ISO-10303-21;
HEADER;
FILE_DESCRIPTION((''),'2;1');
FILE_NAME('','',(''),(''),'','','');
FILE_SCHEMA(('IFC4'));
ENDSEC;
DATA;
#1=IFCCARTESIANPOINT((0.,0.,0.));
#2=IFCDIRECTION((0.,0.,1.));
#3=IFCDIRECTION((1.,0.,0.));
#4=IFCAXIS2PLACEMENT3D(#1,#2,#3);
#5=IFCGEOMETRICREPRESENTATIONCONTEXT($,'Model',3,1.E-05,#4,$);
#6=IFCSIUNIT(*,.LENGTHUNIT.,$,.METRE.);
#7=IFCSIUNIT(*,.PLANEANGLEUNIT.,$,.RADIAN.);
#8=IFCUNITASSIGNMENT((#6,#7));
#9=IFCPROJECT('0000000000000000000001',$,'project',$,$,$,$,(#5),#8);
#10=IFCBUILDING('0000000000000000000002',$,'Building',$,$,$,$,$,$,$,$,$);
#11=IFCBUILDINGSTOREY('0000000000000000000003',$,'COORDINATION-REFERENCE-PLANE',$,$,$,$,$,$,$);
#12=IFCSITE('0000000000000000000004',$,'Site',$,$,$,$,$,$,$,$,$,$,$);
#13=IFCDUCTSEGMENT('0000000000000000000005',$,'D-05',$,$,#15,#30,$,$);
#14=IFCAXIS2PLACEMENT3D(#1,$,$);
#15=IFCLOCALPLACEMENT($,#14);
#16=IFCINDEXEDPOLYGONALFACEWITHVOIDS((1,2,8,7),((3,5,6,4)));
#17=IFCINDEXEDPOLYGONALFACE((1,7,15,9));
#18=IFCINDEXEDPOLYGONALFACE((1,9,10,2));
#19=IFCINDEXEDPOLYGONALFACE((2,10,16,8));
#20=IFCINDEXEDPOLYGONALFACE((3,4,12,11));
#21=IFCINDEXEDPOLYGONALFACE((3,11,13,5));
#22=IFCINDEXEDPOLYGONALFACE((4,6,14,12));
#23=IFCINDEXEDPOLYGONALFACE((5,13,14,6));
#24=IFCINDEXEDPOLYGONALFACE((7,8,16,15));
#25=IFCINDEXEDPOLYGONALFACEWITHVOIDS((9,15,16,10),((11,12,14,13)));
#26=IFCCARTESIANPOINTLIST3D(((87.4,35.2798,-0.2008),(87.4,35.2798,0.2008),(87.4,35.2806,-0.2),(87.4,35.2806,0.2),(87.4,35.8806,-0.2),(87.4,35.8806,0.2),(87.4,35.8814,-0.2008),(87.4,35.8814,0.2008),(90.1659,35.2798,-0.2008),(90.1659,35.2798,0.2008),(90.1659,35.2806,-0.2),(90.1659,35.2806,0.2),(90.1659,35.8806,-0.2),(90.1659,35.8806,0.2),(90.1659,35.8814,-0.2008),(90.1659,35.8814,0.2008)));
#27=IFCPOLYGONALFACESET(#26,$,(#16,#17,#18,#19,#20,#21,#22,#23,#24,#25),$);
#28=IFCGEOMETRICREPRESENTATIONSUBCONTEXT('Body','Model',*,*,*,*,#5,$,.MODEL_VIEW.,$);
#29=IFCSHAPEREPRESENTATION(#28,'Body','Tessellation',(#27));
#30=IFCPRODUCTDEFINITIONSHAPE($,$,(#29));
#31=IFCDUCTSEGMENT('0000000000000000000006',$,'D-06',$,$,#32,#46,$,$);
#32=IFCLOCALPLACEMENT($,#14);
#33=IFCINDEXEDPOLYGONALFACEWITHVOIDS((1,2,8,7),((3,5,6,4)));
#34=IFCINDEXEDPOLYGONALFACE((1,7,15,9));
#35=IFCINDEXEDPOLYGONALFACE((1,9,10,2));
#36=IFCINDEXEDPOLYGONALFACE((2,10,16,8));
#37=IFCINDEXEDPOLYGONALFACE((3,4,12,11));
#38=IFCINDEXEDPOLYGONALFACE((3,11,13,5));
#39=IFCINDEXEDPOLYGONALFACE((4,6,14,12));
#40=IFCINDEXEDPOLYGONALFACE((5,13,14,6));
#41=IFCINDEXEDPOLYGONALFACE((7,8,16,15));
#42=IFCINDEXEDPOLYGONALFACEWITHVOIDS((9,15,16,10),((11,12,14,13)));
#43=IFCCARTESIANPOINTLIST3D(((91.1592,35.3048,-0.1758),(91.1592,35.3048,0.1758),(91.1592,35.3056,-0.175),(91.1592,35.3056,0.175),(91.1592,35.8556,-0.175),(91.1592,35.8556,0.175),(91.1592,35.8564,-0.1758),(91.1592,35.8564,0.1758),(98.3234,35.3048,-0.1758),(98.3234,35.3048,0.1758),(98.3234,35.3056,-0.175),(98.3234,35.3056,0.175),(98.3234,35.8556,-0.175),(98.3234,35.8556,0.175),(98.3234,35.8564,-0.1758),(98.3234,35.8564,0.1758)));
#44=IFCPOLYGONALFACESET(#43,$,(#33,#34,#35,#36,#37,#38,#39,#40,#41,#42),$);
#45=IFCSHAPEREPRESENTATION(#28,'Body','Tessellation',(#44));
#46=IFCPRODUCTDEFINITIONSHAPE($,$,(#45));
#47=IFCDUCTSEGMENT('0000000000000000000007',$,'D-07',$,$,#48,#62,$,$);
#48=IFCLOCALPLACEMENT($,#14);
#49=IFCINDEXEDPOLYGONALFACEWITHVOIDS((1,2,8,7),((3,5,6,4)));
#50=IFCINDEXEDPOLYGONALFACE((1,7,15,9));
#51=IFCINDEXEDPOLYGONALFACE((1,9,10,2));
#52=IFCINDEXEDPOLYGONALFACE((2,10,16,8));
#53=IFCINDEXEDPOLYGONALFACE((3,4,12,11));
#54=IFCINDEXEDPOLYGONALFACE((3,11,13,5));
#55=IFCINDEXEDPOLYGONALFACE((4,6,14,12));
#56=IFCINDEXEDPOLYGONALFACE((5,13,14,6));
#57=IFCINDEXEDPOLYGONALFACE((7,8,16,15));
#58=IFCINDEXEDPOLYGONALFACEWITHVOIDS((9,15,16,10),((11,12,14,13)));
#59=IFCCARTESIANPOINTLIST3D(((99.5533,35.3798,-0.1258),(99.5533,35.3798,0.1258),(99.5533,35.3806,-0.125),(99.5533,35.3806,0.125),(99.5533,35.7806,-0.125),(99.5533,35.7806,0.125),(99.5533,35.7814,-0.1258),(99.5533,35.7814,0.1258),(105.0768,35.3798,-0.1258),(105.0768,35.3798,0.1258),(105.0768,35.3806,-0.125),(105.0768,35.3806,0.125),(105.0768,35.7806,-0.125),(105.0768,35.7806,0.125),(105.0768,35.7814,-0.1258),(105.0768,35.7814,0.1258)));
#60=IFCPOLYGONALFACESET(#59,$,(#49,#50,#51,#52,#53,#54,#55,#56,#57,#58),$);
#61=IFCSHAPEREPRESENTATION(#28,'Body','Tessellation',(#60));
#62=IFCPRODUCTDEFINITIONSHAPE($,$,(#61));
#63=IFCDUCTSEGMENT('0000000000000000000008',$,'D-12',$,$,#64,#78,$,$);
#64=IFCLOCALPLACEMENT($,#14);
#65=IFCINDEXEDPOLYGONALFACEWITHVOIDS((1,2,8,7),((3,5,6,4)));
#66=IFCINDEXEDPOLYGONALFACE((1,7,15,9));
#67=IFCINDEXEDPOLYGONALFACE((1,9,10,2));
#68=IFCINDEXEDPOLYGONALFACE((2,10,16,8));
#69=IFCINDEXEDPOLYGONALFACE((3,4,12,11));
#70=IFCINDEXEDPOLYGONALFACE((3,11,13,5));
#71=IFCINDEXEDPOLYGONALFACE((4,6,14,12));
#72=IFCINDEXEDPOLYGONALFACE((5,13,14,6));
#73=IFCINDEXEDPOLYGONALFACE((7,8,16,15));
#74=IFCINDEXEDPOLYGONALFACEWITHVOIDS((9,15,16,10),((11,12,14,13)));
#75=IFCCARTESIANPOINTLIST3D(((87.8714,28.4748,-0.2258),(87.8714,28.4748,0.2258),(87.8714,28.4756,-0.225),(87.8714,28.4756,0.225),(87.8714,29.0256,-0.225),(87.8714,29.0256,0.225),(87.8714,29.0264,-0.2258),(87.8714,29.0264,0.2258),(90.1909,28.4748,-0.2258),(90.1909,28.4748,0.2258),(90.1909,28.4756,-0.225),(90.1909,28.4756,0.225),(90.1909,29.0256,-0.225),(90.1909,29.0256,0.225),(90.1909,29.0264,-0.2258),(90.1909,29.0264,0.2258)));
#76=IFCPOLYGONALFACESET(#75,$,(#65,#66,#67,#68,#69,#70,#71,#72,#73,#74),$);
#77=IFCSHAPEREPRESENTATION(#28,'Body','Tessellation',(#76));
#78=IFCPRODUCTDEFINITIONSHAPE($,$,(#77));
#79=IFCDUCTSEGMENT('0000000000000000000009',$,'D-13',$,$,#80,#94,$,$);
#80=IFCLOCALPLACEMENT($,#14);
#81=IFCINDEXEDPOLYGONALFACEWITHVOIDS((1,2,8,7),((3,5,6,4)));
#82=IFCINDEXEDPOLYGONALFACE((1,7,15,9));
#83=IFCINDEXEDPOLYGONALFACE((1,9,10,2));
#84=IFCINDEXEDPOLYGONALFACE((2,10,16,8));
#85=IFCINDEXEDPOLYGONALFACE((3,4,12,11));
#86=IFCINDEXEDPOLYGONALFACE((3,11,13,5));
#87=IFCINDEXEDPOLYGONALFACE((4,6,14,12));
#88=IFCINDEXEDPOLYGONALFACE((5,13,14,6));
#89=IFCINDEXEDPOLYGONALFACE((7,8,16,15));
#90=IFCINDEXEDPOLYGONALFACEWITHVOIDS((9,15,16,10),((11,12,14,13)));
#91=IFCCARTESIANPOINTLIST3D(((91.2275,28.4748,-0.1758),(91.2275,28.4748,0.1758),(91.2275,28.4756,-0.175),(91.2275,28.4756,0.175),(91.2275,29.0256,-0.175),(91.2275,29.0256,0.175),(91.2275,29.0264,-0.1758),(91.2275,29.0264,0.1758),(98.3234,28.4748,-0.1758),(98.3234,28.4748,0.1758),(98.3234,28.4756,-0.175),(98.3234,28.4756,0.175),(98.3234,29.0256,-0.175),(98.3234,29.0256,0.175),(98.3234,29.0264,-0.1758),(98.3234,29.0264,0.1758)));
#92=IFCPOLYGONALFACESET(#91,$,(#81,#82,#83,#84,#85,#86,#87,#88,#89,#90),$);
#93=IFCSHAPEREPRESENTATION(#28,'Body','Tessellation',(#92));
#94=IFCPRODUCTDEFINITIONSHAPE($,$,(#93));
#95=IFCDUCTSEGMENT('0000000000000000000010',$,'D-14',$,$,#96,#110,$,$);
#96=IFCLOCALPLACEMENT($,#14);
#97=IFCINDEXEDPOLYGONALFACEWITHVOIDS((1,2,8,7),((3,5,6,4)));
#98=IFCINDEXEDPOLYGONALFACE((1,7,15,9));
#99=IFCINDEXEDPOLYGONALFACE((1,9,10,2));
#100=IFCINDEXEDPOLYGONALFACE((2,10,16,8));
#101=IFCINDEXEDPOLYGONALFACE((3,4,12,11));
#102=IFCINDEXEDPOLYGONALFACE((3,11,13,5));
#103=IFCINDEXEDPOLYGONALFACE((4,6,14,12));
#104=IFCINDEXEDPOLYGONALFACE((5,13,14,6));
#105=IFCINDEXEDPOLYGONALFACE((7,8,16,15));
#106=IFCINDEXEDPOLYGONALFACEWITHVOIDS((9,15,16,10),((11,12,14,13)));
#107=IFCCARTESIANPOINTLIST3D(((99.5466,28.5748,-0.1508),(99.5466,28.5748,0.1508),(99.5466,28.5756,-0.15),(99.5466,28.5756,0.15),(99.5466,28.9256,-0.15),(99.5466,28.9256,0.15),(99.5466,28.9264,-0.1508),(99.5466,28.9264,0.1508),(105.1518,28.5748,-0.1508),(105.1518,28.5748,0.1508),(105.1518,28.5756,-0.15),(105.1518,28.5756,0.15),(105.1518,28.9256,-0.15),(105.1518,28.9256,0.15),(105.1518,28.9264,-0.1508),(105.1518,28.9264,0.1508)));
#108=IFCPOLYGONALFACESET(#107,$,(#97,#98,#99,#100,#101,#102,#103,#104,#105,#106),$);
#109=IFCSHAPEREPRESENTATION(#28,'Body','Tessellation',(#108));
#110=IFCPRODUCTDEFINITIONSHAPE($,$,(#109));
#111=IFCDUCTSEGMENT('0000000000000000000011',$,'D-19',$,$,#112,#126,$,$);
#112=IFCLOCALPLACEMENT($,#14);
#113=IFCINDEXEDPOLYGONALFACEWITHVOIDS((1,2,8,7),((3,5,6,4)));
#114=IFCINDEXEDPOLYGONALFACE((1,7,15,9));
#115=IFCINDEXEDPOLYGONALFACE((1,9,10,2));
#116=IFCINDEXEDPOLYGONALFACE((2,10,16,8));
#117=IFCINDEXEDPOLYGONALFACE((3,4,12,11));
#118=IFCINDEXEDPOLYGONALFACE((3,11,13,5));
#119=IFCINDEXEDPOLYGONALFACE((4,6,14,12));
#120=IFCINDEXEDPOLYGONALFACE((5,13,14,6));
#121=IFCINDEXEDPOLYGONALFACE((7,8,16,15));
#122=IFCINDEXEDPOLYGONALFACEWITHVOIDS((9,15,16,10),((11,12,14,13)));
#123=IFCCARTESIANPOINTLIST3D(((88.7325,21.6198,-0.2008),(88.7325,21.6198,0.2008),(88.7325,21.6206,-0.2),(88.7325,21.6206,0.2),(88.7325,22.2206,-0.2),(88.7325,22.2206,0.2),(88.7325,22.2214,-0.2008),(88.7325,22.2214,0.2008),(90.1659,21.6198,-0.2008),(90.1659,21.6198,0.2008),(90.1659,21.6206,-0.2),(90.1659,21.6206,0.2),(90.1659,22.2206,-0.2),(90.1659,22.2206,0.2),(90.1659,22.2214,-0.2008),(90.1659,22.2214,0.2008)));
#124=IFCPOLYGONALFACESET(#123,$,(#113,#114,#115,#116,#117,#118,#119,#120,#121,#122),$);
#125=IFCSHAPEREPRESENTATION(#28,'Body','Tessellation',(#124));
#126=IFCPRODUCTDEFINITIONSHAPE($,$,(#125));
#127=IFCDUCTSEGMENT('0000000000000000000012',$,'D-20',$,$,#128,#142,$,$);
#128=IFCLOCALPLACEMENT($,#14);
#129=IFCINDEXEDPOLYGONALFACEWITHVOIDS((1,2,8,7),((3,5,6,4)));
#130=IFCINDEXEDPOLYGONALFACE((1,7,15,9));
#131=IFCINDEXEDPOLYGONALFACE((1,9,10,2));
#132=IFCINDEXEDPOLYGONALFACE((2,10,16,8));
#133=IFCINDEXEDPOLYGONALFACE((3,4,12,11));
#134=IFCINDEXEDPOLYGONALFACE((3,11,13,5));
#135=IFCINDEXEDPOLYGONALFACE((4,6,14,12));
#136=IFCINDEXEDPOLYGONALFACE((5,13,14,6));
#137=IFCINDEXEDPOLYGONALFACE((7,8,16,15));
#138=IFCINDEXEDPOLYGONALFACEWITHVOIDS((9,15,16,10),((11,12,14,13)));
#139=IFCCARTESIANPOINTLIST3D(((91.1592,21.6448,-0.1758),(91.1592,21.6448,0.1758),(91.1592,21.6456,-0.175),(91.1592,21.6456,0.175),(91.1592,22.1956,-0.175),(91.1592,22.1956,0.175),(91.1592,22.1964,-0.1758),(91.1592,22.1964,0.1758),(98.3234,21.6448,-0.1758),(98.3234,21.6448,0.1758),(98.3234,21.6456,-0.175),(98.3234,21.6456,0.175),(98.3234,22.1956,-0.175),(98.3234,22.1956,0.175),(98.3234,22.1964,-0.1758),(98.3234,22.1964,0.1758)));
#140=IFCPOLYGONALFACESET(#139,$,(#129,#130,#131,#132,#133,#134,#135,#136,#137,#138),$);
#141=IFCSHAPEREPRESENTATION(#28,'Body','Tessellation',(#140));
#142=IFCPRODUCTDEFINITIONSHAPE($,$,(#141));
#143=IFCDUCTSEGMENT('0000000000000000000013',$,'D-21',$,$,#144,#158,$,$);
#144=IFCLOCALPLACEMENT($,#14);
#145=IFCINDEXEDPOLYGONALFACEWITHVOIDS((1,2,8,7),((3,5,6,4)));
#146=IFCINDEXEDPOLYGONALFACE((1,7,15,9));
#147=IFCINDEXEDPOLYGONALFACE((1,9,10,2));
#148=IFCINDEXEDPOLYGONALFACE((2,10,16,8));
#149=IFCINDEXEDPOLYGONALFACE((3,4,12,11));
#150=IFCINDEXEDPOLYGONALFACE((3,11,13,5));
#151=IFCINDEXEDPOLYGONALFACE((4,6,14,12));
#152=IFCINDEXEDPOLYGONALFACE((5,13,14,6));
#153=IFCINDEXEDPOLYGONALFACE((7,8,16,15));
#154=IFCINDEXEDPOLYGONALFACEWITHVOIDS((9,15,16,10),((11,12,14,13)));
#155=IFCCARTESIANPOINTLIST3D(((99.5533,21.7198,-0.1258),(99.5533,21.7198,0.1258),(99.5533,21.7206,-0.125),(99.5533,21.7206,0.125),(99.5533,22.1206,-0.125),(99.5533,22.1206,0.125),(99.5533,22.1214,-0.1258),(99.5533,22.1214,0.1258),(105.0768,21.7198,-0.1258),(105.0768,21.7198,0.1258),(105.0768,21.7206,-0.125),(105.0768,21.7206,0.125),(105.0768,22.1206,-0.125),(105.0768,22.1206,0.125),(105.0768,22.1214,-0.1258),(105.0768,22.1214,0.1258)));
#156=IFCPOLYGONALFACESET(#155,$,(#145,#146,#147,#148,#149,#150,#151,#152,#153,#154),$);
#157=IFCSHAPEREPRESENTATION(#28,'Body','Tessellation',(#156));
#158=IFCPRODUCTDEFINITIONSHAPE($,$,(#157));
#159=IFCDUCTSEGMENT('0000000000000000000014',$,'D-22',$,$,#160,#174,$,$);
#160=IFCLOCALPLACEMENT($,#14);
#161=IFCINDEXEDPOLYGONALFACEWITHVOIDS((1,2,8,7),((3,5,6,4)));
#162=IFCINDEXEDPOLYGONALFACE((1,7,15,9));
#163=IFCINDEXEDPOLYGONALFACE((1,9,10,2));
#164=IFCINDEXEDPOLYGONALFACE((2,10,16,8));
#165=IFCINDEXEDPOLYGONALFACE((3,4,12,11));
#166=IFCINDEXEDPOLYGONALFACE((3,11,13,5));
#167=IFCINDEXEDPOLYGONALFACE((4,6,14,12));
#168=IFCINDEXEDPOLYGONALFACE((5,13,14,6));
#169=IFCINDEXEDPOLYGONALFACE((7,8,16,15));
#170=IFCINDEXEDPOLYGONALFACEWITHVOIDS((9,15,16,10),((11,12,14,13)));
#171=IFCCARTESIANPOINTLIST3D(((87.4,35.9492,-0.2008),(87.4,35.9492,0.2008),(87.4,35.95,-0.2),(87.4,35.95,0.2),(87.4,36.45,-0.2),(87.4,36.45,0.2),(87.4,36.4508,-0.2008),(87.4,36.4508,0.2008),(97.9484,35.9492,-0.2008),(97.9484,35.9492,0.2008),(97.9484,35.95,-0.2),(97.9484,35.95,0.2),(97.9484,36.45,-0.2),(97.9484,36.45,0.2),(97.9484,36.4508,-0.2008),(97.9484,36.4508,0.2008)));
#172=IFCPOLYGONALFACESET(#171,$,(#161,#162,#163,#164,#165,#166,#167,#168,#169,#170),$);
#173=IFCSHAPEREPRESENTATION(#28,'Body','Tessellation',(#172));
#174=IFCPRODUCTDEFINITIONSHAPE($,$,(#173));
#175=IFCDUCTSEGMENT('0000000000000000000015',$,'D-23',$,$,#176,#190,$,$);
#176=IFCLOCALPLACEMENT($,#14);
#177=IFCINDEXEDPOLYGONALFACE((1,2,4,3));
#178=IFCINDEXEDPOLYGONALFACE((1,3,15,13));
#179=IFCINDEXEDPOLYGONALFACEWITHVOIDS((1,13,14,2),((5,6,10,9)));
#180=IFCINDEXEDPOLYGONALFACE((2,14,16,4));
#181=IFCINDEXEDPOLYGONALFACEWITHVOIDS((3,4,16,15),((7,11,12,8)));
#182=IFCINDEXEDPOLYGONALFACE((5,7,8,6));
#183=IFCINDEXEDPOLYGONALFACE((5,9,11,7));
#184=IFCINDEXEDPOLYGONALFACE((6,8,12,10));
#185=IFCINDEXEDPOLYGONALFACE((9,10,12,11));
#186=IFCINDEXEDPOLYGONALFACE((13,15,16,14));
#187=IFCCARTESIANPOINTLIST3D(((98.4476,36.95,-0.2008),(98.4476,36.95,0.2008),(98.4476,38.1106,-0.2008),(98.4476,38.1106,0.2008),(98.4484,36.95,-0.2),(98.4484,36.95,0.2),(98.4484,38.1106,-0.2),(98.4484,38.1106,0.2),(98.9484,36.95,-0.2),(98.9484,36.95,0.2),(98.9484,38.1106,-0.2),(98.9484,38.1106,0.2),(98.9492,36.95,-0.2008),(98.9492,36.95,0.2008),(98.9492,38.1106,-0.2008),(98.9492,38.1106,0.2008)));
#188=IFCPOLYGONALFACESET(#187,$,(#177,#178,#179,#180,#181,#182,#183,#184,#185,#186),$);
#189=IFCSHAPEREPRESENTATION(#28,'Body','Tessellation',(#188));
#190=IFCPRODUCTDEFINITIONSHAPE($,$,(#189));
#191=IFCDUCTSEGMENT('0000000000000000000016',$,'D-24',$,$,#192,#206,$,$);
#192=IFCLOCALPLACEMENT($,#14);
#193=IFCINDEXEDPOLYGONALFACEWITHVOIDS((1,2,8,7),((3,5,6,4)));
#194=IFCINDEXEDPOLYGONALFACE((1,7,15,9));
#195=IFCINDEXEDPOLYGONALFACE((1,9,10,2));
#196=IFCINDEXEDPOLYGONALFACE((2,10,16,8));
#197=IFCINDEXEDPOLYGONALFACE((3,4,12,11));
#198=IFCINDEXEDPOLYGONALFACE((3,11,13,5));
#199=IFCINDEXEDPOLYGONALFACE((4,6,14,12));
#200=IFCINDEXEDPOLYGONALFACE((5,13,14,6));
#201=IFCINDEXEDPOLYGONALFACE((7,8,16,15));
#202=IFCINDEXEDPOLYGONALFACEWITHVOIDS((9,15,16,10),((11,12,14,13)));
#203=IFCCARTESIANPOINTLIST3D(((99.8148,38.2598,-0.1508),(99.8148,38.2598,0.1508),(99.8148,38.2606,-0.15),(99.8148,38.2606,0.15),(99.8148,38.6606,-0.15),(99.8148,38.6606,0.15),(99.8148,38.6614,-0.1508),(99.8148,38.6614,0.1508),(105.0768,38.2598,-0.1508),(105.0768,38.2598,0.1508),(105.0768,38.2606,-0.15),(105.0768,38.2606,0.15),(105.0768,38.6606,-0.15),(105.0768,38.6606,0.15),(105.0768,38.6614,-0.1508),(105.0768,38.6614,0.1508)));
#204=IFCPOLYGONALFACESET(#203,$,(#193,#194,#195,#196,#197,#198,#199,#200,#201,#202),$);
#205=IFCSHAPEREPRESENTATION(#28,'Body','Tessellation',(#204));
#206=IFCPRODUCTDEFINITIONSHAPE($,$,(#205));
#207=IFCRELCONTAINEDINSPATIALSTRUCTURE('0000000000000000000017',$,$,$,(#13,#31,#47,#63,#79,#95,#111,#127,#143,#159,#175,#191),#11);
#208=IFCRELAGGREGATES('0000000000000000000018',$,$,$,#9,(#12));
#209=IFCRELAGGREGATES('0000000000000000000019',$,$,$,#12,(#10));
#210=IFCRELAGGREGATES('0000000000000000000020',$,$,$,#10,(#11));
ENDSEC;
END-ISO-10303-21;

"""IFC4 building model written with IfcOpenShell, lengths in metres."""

from ifc_helpers import new_model, si_unit, frame, origin, origin_with_axes, place, context, subcontext, project, spatial, hollow_rectangle, extrude, element, save


model = new_model("IFC4")

# Units and contexts
model_context = context("Model", 3, precision=1e-05, world=origin_with_axes())
body_context = subcontext(model_context, "Body", "Model", "MODEL_VIEW")
ifc_project = project(units=[si_unit("LENGTHUNIT", "METRE"), si_unit("PLANEANGLEUNIT", "RADIAN")], contexts=[model_context])

# Site, building, storey
site = spatial("IfcSite", under=ifc_project, Name="Site")
building = spatial("IfcBuilding", under=site, Name="Building")
storey = spatial("IfcBuildingStorey", under=building, Name="COORDINATION-REFERENCE-PLANE")

# Duct segments
duct_segment_1_placement = place(None, frame((87.4, 35.5806, 0.0), z_axis=(1.0, 0.0, 0.0), x_axis=(0.0, 1.0, 0.0)))
element("IfcDuctSegment", 1, at=duct_segment_1_placement, inside=storey, Name="D-05", context=body_context, shape_type="SweptSolid", body=[
    extrude(hollow_rectangle(XDim=0.6016, YDim=0.4016, WallThickness=0.0008), origin(), (0.0, 0.0, 1.0), 2.7659),
])
duct_segment_2_placement = place(None, frame((91.1592, 35.5806, 0.0), z_axis=(1.0, 0.0, 0.0), x_axis=(0.0, 1.0, 0.0)))
element("IfcDuctSegment", 2, at=duct_segment_2_placement, inside=storey, Name="D-06", context=body_context, shape_type="SweptSolid", body=[
    extrude(hollow_rectangle(XDim=0.5516, YDim=0.3516, WallThickness=0.0008), origin(), (0.0, 0.0, 1.0), 7.1642),
])
duct_segment_3_placement = place(None, frame((99.5533, 35.5806, 0.0), z_axis=(1.0, 0.0, 0.0), x_axis=(0.0, 1.0, 0.0)))
element("IfcDuctSegment", 3, at=duct_segment_3_placement, inside=storey, Name="D-07", context=body_context, shape_type="SweptSolid", body=[
    extrude(hollow_rectangle(XDim=0.4016, YDim=0.2516, WallThickness=0.0008), origin(), (0.0, 0.0, 1.0), 5.5234),
])
duct_segment_4_placement = place(None, frame((87.8714, 28.7506, 0.0), z_axis=(1.0, 0.0, 0.0), x_axis=(0.0, 1.0, 0.0)))
element("IfcDuctSegment", 4, at=duct_segment_4_placement, inside=storey, Name="D-12", context=body_context, shape_type="SweptSolid", body=[
    extrude(hollow_rectangle(XDim=0.5516, YDim=0.4516, WallThickness=0.0008), origin(), (0.0, 0.0, 1.0), 2.3195),
])
duct_segment_5_placement = place(None, frame((91.2275, 28.7506, 0.0), z_axis=(1.0, 0.0, 0.0), x_axis=(0.0, 1.0, 0.0)))
element("IfcDuctSegment", 5, at=duct_segment_5_placement, inside=storey, Name="D-13", context=body_context, shape_type="SweptSolid", body=[
    extrude(hollow_rectangle(XDim=0.5516, YDim=0.3516, WallThickness=0.0008), origin(), (0.0, 0.0, 1.0), 7.0959),
])
duct_segment_6_placement = place(None, frame((99.5466, 28.7506, 0.0), z_axis=(1.0, 0.0, 0.0), x_axis=(0.0, 1.0, 0.0)))
element("IfcDuctSegment", 6, at=duct_segment_6_placement, inside=storey, Name="D-14", context=body_context, shape_type="SweptSolid", body=[
    extrude(hollow_rectangle(XDim=0.3516, YDim=0.3016, WallThickness=0.0008), origin(), (0.0, 0.0, 1.0), 5.6051),
])
duct_segment_7_placement = place(None, frame((88.7325, 21.9206, 0.0), z_axis=(1.0, 0.0, 0.0), x_axis=(0.0, 1.0, 0.0)))
element("IfcDuctSegment", 7, at=duct_segment_7_placement, inside=storey, Name="D-19", context=body_context, shape_type="SweptSolid", body=[
    extrude(hollow_rectangle(XDim=0.6016, YDim=0.4016, WallThickness=0.0008), origin(), (0.0, 0.0, 1.0), 1.4334),
])
duct_segment_8_placement = place(None, frame((91.1592, 21.9206, 0.0), z_axis=(1.0, 0.0, 0.0), x_axis=(0.0, 1.0, 0.0)))
element("IfcDuctSegment", 8, at=duct_segment_8_placement, inside=storey, Name="D-20", context=body_context, shape_type="SweptSolid", body=[
    extrude(hollow_rectangle(XDim=0.5516, YDim=0.3516, WallThickness=0.0008), origin(), (0.0, 0.0, 1.0), 7.1642),
])
duct_segment_9_placement = place(None, frame((99.5533, 21.9206, 0.0), z_axis=(1.0, 0.0, 0.0), x_axis=(0.0, 1.0, 0.0)))
element("IfcDuctSegment", 9, at=duct_segment_9_placement, inside=storey, Name="D-21", context=body_context, shape_type="SweptSolid", body=[
    extrude(hollow_rectangle(XDim=0.4016, YDim=0.2516, WallThickness=0.0008), origin(), (0.0, 0.0, 1.0), 5.5234),
])
duct_segment_10_placement = place(None, frame((87.4, 36.2, 0.0), z_axis=(1.0, 0.0, 0.0), x_axis=(0.0, 1.0, 0.0)))
element("IfcDuctSegment", 10, at=duct_segment_10_placement, inside=storey, Name="D-22", context=body_context, shape_type="SweptSolid", body=[
    extrude(hollow_rectangle(XDim=0.5016, YDim=0.4016, WallThickness=0.0008), origin(), (0.0, 0.0, 1.0), 10.5484),
])
duct_segment_11_placement = place(None, frame((98.6984, 36.95, 0.0), z_axis=(0.0, 1.0, 0.0), x_axis=(1.0, 0.0, 0.0)))
element("IfcDuctSegment", 11, at=duct_segment_11_placement, inside=storey, Name="D-23", context=body_context, shape_type="SweptSolid", body=[
    extrude(hollow_rectangle(XDim=0.5016, YDim=0.4016, WallThickness=0.0008), origin(), (0.0, 0.0, 1.0), 1.1606),
])
duct_segment_12_placement = place(None, frame((99.8148, 38.4606, 0.0), z_axis=(1.0, 0.0, 0.0), x_axis=(0.0, 1.0, 0.0)))
element("IfcDuctSegment", 12, at=duct_segment_12_placement, inside=storey, Name="D-24", context=body_context, shape_type="SweptSolid", body=[
    extrude(hollow_rectangle(XDim=0.4016, YDim=0.3016, WallThickness=0.0008), origin(), (0.0, 0.0, 1.0), 5.2619),
])

save(model, "model.ifc")
